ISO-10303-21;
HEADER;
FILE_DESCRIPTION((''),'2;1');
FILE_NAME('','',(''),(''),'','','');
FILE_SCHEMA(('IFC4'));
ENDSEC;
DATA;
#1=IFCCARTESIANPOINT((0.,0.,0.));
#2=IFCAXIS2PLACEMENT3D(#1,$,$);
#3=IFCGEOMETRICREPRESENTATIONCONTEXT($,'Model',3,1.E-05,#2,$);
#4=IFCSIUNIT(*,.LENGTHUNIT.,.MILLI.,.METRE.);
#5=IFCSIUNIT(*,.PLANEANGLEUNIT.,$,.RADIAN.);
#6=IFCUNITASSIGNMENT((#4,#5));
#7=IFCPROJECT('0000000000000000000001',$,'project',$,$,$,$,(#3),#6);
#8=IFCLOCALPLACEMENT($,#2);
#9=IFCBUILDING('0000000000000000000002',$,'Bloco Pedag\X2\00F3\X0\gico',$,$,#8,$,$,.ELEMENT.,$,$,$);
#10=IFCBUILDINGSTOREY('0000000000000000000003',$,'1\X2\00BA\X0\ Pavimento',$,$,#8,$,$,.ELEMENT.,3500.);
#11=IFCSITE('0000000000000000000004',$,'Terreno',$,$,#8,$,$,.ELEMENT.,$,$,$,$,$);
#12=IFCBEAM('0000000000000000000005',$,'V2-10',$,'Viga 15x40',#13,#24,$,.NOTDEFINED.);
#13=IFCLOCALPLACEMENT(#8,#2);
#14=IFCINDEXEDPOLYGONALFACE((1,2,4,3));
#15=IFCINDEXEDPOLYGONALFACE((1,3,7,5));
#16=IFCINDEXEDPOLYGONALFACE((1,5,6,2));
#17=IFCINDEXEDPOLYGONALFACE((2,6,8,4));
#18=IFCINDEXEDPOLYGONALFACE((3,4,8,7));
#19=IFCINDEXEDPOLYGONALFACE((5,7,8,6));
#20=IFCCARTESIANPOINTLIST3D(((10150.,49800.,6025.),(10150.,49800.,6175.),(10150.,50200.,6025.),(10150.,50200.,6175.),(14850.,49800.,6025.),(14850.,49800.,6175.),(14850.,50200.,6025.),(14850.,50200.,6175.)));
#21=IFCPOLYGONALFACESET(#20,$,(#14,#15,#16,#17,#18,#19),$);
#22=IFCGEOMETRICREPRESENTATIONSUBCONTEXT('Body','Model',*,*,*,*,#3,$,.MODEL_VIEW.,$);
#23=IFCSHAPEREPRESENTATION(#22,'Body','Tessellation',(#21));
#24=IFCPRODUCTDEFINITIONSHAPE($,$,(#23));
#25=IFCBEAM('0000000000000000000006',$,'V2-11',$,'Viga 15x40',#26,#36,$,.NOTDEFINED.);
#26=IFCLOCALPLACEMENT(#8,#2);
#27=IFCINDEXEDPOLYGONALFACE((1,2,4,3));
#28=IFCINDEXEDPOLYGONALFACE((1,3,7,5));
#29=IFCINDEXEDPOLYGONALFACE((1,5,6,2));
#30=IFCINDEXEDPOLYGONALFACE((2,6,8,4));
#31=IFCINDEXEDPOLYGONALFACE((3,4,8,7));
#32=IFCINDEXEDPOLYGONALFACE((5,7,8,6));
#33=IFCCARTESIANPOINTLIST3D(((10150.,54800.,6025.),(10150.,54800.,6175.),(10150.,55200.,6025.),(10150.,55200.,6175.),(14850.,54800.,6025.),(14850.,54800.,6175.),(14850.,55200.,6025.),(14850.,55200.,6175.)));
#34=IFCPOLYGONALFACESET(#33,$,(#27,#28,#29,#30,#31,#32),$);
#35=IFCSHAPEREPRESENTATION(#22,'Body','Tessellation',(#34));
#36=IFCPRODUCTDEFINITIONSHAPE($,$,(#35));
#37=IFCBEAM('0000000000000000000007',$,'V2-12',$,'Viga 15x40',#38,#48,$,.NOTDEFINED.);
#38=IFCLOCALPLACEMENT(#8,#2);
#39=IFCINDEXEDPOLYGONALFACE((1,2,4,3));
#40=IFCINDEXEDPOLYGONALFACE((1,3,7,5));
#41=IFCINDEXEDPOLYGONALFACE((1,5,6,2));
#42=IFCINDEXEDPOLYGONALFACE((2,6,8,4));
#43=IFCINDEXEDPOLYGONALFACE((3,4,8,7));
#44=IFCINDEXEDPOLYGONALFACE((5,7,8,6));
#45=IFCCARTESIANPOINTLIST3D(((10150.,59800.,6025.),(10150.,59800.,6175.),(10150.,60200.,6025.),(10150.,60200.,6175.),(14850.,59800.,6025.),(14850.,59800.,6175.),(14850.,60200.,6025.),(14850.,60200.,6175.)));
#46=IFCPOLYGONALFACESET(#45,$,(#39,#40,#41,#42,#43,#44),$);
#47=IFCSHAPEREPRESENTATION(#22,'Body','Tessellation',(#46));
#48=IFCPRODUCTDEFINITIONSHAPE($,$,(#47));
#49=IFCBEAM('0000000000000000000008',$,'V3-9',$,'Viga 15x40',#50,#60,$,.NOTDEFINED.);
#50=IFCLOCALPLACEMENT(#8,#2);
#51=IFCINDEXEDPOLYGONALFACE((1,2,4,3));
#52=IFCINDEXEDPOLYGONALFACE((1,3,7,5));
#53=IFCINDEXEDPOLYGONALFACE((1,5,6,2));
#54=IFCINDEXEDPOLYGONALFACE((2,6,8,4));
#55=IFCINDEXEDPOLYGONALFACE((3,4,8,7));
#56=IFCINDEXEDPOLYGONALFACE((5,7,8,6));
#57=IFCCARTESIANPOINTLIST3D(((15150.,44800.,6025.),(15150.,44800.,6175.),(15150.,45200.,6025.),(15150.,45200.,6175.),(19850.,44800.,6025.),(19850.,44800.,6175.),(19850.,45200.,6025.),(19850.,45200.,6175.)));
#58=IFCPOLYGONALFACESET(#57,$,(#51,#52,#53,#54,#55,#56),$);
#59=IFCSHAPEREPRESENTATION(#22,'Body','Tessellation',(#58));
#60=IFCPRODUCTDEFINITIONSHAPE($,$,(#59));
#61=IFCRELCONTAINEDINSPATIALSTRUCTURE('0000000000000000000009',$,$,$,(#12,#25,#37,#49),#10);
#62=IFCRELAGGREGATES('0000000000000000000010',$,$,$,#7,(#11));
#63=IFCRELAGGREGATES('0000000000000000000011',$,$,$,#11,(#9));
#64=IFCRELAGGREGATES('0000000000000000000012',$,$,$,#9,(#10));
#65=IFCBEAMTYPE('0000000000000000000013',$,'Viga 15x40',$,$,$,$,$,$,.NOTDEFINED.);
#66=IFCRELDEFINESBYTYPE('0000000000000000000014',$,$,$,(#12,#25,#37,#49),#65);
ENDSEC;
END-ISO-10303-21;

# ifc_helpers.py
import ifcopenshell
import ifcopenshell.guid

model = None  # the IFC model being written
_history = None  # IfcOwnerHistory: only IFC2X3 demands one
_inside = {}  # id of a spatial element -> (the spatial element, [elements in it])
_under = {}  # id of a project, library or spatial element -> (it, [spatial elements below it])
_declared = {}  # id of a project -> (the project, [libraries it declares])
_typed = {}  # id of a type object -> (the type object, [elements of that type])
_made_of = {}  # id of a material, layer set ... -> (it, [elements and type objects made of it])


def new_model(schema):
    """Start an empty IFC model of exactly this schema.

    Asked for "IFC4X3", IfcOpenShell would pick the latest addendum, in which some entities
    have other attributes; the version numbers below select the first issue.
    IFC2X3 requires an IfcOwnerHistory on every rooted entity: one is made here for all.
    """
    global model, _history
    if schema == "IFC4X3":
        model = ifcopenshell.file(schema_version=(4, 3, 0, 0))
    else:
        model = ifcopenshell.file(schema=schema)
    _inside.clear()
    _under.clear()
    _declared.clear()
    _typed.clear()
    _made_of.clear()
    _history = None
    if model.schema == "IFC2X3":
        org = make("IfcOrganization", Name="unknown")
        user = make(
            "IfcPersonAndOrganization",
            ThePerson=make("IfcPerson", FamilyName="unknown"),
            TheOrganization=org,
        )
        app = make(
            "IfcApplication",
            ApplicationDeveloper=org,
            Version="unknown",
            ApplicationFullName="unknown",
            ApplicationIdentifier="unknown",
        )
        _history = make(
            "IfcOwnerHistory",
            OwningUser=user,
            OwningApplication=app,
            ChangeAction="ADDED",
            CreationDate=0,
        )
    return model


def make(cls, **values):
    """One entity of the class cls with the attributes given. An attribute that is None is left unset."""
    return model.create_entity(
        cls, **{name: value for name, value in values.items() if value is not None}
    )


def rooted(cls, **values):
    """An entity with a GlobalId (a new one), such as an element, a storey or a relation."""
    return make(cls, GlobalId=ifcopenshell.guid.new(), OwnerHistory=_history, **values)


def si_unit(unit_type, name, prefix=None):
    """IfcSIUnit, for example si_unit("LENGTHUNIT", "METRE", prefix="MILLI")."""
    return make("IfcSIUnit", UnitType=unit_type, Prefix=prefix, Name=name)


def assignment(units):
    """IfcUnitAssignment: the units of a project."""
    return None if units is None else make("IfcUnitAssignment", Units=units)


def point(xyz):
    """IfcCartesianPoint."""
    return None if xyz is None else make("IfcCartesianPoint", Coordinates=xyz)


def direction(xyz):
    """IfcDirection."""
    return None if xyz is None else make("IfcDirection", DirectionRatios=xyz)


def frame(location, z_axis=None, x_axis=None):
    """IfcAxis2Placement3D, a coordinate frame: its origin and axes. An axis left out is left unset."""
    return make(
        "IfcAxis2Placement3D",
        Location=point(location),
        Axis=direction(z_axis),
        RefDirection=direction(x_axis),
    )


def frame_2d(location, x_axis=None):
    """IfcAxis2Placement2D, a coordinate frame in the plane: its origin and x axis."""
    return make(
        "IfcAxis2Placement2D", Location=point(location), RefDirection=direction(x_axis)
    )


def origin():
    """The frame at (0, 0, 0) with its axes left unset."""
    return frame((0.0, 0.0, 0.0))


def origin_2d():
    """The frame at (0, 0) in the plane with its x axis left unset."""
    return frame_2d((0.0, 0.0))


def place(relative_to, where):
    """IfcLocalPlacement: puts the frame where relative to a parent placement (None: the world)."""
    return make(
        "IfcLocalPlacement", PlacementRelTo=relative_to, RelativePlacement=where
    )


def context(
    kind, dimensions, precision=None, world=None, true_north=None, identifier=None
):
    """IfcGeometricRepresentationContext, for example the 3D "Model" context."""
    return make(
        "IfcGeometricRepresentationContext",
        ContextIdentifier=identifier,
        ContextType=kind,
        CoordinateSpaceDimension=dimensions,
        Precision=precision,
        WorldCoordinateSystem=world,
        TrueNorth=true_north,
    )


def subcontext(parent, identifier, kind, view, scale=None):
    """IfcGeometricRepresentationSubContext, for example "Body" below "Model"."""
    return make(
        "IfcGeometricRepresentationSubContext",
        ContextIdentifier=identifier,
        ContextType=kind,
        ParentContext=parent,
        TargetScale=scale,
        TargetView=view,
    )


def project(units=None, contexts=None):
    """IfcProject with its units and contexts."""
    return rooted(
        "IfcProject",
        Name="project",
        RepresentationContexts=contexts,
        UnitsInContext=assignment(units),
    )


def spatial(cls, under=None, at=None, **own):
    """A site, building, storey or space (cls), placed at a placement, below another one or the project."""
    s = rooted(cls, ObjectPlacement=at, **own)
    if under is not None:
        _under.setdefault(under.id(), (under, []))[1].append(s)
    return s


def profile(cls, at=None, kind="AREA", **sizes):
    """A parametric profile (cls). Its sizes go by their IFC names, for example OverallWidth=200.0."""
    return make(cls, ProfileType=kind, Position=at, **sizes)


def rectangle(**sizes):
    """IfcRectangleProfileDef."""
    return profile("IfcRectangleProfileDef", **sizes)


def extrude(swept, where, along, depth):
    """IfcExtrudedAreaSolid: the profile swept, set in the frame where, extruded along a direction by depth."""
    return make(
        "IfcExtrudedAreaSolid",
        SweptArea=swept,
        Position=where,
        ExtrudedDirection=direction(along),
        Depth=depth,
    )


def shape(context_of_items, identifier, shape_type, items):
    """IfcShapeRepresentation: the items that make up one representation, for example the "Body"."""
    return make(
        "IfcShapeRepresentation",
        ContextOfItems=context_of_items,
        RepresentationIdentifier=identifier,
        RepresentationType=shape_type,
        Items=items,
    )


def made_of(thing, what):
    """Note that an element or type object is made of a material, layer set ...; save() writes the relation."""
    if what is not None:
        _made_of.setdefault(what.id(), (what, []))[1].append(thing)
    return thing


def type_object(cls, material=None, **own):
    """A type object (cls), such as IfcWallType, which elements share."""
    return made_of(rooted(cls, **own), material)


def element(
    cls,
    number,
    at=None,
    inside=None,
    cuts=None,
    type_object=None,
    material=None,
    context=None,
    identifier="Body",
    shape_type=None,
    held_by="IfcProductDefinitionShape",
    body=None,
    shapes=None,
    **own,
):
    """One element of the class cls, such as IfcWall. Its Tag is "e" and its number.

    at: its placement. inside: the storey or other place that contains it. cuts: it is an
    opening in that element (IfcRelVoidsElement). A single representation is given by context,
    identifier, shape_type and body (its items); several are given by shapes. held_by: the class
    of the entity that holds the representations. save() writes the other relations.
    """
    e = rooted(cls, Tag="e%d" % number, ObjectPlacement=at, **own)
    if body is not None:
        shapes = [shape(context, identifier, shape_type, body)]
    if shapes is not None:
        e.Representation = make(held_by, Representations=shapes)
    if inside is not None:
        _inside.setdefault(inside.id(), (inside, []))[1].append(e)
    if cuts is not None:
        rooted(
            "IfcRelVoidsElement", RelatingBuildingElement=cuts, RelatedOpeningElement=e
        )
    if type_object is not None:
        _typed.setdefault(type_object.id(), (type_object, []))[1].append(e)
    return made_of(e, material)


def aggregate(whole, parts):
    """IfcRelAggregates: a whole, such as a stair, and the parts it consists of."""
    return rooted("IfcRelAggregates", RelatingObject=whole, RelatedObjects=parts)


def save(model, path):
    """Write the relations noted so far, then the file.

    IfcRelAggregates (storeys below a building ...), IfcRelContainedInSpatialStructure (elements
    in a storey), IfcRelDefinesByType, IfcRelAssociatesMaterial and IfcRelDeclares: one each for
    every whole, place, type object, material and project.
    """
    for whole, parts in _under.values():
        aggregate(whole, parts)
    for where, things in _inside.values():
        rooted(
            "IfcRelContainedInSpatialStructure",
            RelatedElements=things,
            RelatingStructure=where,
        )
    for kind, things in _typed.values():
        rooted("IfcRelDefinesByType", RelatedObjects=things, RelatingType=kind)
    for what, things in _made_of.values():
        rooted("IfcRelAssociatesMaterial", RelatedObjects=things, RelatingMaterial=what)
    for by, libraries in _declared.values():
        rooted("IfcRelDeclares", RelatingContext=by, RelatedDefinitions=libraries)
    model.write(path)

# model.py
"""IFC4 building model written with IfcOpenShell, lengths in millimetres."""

from ifc_helpers import new_model, si_unit, frame, origin, origin_2d, place, context, subcontext, project, spatial, rectangle, extrude, type_object, element, save


model = new_model("IFC4")

# Units and contexts
model_context = context("Model", 3, precision=1e-05, world=origin())
body_context = subcontext(model_context, "Body", "Model", "MODEL_VIEW")
ifc_project = project(units=[si_unit("LENGTHUNIT", "METRE", prefix="MILLI"), si_unit("PLANEANGLEUNIT", "RADIAN")], contexts=[model_context])

# Site, building, storey
placement = place(None, origin())
site = spatial("IfcSite", under=ifc_project, at=placement, Name="Terreno", CompositionType="ELEMENT")
building = spatial("IfcBuilding", under=site, at=placement, Name="Bloco Pedagógico", CompositionType="ELEMENT")
storey = spatial("IfcBuildingStorey", under=building, at=placement, Name="1º Pavimento", CompositionType="ELEMENT", Elevation=3500.0)

# Beams
beam_type = type_object("IfcBeamType", Name="Viga 15x40", PredefinedType="NOTDEFINED")
for number, where, z_axis, x_axis, name in (
    (1, (10150.0, 50000.0, 6100.0), (1.0, 0.0, 0.0), (0.0, 1.0, 0.0), "V2-10"),
    (2, (10150.0, 55000.0, 6100.0), (1.0, 0.0, 0.0), (0.0, 1.0, 0.0), "V2-11"),
    (3, (10150.0, 60000.0, 6100.0), (1.0, 0.0, 0.0), (0.0, 1.0, 0.0), "V2-12"),
    (4, (15150.0, 45000.0, 6100.0), (1.0, 0.0, 0.0), (0.0, 1.0, 0.0), "V3-9"),
):
    element("IfcBeam", number, at=place(None, frame(where, z_axis=z_axis, x_axis=x_axis)), inside=storey, type_object=beam_type, Name=name, ObjectType="Viga 15x40", PredefinedType="NOTDEFINED", context=body_context, shape_type="SweptSolid", body=[
        extrude(rectangle(XDim=400.0, YDim=150.0, at=origin_2d()), None, (0.0, 0.0, 1.0), 4700.0),
    ])

save(model, "model.ifc")
